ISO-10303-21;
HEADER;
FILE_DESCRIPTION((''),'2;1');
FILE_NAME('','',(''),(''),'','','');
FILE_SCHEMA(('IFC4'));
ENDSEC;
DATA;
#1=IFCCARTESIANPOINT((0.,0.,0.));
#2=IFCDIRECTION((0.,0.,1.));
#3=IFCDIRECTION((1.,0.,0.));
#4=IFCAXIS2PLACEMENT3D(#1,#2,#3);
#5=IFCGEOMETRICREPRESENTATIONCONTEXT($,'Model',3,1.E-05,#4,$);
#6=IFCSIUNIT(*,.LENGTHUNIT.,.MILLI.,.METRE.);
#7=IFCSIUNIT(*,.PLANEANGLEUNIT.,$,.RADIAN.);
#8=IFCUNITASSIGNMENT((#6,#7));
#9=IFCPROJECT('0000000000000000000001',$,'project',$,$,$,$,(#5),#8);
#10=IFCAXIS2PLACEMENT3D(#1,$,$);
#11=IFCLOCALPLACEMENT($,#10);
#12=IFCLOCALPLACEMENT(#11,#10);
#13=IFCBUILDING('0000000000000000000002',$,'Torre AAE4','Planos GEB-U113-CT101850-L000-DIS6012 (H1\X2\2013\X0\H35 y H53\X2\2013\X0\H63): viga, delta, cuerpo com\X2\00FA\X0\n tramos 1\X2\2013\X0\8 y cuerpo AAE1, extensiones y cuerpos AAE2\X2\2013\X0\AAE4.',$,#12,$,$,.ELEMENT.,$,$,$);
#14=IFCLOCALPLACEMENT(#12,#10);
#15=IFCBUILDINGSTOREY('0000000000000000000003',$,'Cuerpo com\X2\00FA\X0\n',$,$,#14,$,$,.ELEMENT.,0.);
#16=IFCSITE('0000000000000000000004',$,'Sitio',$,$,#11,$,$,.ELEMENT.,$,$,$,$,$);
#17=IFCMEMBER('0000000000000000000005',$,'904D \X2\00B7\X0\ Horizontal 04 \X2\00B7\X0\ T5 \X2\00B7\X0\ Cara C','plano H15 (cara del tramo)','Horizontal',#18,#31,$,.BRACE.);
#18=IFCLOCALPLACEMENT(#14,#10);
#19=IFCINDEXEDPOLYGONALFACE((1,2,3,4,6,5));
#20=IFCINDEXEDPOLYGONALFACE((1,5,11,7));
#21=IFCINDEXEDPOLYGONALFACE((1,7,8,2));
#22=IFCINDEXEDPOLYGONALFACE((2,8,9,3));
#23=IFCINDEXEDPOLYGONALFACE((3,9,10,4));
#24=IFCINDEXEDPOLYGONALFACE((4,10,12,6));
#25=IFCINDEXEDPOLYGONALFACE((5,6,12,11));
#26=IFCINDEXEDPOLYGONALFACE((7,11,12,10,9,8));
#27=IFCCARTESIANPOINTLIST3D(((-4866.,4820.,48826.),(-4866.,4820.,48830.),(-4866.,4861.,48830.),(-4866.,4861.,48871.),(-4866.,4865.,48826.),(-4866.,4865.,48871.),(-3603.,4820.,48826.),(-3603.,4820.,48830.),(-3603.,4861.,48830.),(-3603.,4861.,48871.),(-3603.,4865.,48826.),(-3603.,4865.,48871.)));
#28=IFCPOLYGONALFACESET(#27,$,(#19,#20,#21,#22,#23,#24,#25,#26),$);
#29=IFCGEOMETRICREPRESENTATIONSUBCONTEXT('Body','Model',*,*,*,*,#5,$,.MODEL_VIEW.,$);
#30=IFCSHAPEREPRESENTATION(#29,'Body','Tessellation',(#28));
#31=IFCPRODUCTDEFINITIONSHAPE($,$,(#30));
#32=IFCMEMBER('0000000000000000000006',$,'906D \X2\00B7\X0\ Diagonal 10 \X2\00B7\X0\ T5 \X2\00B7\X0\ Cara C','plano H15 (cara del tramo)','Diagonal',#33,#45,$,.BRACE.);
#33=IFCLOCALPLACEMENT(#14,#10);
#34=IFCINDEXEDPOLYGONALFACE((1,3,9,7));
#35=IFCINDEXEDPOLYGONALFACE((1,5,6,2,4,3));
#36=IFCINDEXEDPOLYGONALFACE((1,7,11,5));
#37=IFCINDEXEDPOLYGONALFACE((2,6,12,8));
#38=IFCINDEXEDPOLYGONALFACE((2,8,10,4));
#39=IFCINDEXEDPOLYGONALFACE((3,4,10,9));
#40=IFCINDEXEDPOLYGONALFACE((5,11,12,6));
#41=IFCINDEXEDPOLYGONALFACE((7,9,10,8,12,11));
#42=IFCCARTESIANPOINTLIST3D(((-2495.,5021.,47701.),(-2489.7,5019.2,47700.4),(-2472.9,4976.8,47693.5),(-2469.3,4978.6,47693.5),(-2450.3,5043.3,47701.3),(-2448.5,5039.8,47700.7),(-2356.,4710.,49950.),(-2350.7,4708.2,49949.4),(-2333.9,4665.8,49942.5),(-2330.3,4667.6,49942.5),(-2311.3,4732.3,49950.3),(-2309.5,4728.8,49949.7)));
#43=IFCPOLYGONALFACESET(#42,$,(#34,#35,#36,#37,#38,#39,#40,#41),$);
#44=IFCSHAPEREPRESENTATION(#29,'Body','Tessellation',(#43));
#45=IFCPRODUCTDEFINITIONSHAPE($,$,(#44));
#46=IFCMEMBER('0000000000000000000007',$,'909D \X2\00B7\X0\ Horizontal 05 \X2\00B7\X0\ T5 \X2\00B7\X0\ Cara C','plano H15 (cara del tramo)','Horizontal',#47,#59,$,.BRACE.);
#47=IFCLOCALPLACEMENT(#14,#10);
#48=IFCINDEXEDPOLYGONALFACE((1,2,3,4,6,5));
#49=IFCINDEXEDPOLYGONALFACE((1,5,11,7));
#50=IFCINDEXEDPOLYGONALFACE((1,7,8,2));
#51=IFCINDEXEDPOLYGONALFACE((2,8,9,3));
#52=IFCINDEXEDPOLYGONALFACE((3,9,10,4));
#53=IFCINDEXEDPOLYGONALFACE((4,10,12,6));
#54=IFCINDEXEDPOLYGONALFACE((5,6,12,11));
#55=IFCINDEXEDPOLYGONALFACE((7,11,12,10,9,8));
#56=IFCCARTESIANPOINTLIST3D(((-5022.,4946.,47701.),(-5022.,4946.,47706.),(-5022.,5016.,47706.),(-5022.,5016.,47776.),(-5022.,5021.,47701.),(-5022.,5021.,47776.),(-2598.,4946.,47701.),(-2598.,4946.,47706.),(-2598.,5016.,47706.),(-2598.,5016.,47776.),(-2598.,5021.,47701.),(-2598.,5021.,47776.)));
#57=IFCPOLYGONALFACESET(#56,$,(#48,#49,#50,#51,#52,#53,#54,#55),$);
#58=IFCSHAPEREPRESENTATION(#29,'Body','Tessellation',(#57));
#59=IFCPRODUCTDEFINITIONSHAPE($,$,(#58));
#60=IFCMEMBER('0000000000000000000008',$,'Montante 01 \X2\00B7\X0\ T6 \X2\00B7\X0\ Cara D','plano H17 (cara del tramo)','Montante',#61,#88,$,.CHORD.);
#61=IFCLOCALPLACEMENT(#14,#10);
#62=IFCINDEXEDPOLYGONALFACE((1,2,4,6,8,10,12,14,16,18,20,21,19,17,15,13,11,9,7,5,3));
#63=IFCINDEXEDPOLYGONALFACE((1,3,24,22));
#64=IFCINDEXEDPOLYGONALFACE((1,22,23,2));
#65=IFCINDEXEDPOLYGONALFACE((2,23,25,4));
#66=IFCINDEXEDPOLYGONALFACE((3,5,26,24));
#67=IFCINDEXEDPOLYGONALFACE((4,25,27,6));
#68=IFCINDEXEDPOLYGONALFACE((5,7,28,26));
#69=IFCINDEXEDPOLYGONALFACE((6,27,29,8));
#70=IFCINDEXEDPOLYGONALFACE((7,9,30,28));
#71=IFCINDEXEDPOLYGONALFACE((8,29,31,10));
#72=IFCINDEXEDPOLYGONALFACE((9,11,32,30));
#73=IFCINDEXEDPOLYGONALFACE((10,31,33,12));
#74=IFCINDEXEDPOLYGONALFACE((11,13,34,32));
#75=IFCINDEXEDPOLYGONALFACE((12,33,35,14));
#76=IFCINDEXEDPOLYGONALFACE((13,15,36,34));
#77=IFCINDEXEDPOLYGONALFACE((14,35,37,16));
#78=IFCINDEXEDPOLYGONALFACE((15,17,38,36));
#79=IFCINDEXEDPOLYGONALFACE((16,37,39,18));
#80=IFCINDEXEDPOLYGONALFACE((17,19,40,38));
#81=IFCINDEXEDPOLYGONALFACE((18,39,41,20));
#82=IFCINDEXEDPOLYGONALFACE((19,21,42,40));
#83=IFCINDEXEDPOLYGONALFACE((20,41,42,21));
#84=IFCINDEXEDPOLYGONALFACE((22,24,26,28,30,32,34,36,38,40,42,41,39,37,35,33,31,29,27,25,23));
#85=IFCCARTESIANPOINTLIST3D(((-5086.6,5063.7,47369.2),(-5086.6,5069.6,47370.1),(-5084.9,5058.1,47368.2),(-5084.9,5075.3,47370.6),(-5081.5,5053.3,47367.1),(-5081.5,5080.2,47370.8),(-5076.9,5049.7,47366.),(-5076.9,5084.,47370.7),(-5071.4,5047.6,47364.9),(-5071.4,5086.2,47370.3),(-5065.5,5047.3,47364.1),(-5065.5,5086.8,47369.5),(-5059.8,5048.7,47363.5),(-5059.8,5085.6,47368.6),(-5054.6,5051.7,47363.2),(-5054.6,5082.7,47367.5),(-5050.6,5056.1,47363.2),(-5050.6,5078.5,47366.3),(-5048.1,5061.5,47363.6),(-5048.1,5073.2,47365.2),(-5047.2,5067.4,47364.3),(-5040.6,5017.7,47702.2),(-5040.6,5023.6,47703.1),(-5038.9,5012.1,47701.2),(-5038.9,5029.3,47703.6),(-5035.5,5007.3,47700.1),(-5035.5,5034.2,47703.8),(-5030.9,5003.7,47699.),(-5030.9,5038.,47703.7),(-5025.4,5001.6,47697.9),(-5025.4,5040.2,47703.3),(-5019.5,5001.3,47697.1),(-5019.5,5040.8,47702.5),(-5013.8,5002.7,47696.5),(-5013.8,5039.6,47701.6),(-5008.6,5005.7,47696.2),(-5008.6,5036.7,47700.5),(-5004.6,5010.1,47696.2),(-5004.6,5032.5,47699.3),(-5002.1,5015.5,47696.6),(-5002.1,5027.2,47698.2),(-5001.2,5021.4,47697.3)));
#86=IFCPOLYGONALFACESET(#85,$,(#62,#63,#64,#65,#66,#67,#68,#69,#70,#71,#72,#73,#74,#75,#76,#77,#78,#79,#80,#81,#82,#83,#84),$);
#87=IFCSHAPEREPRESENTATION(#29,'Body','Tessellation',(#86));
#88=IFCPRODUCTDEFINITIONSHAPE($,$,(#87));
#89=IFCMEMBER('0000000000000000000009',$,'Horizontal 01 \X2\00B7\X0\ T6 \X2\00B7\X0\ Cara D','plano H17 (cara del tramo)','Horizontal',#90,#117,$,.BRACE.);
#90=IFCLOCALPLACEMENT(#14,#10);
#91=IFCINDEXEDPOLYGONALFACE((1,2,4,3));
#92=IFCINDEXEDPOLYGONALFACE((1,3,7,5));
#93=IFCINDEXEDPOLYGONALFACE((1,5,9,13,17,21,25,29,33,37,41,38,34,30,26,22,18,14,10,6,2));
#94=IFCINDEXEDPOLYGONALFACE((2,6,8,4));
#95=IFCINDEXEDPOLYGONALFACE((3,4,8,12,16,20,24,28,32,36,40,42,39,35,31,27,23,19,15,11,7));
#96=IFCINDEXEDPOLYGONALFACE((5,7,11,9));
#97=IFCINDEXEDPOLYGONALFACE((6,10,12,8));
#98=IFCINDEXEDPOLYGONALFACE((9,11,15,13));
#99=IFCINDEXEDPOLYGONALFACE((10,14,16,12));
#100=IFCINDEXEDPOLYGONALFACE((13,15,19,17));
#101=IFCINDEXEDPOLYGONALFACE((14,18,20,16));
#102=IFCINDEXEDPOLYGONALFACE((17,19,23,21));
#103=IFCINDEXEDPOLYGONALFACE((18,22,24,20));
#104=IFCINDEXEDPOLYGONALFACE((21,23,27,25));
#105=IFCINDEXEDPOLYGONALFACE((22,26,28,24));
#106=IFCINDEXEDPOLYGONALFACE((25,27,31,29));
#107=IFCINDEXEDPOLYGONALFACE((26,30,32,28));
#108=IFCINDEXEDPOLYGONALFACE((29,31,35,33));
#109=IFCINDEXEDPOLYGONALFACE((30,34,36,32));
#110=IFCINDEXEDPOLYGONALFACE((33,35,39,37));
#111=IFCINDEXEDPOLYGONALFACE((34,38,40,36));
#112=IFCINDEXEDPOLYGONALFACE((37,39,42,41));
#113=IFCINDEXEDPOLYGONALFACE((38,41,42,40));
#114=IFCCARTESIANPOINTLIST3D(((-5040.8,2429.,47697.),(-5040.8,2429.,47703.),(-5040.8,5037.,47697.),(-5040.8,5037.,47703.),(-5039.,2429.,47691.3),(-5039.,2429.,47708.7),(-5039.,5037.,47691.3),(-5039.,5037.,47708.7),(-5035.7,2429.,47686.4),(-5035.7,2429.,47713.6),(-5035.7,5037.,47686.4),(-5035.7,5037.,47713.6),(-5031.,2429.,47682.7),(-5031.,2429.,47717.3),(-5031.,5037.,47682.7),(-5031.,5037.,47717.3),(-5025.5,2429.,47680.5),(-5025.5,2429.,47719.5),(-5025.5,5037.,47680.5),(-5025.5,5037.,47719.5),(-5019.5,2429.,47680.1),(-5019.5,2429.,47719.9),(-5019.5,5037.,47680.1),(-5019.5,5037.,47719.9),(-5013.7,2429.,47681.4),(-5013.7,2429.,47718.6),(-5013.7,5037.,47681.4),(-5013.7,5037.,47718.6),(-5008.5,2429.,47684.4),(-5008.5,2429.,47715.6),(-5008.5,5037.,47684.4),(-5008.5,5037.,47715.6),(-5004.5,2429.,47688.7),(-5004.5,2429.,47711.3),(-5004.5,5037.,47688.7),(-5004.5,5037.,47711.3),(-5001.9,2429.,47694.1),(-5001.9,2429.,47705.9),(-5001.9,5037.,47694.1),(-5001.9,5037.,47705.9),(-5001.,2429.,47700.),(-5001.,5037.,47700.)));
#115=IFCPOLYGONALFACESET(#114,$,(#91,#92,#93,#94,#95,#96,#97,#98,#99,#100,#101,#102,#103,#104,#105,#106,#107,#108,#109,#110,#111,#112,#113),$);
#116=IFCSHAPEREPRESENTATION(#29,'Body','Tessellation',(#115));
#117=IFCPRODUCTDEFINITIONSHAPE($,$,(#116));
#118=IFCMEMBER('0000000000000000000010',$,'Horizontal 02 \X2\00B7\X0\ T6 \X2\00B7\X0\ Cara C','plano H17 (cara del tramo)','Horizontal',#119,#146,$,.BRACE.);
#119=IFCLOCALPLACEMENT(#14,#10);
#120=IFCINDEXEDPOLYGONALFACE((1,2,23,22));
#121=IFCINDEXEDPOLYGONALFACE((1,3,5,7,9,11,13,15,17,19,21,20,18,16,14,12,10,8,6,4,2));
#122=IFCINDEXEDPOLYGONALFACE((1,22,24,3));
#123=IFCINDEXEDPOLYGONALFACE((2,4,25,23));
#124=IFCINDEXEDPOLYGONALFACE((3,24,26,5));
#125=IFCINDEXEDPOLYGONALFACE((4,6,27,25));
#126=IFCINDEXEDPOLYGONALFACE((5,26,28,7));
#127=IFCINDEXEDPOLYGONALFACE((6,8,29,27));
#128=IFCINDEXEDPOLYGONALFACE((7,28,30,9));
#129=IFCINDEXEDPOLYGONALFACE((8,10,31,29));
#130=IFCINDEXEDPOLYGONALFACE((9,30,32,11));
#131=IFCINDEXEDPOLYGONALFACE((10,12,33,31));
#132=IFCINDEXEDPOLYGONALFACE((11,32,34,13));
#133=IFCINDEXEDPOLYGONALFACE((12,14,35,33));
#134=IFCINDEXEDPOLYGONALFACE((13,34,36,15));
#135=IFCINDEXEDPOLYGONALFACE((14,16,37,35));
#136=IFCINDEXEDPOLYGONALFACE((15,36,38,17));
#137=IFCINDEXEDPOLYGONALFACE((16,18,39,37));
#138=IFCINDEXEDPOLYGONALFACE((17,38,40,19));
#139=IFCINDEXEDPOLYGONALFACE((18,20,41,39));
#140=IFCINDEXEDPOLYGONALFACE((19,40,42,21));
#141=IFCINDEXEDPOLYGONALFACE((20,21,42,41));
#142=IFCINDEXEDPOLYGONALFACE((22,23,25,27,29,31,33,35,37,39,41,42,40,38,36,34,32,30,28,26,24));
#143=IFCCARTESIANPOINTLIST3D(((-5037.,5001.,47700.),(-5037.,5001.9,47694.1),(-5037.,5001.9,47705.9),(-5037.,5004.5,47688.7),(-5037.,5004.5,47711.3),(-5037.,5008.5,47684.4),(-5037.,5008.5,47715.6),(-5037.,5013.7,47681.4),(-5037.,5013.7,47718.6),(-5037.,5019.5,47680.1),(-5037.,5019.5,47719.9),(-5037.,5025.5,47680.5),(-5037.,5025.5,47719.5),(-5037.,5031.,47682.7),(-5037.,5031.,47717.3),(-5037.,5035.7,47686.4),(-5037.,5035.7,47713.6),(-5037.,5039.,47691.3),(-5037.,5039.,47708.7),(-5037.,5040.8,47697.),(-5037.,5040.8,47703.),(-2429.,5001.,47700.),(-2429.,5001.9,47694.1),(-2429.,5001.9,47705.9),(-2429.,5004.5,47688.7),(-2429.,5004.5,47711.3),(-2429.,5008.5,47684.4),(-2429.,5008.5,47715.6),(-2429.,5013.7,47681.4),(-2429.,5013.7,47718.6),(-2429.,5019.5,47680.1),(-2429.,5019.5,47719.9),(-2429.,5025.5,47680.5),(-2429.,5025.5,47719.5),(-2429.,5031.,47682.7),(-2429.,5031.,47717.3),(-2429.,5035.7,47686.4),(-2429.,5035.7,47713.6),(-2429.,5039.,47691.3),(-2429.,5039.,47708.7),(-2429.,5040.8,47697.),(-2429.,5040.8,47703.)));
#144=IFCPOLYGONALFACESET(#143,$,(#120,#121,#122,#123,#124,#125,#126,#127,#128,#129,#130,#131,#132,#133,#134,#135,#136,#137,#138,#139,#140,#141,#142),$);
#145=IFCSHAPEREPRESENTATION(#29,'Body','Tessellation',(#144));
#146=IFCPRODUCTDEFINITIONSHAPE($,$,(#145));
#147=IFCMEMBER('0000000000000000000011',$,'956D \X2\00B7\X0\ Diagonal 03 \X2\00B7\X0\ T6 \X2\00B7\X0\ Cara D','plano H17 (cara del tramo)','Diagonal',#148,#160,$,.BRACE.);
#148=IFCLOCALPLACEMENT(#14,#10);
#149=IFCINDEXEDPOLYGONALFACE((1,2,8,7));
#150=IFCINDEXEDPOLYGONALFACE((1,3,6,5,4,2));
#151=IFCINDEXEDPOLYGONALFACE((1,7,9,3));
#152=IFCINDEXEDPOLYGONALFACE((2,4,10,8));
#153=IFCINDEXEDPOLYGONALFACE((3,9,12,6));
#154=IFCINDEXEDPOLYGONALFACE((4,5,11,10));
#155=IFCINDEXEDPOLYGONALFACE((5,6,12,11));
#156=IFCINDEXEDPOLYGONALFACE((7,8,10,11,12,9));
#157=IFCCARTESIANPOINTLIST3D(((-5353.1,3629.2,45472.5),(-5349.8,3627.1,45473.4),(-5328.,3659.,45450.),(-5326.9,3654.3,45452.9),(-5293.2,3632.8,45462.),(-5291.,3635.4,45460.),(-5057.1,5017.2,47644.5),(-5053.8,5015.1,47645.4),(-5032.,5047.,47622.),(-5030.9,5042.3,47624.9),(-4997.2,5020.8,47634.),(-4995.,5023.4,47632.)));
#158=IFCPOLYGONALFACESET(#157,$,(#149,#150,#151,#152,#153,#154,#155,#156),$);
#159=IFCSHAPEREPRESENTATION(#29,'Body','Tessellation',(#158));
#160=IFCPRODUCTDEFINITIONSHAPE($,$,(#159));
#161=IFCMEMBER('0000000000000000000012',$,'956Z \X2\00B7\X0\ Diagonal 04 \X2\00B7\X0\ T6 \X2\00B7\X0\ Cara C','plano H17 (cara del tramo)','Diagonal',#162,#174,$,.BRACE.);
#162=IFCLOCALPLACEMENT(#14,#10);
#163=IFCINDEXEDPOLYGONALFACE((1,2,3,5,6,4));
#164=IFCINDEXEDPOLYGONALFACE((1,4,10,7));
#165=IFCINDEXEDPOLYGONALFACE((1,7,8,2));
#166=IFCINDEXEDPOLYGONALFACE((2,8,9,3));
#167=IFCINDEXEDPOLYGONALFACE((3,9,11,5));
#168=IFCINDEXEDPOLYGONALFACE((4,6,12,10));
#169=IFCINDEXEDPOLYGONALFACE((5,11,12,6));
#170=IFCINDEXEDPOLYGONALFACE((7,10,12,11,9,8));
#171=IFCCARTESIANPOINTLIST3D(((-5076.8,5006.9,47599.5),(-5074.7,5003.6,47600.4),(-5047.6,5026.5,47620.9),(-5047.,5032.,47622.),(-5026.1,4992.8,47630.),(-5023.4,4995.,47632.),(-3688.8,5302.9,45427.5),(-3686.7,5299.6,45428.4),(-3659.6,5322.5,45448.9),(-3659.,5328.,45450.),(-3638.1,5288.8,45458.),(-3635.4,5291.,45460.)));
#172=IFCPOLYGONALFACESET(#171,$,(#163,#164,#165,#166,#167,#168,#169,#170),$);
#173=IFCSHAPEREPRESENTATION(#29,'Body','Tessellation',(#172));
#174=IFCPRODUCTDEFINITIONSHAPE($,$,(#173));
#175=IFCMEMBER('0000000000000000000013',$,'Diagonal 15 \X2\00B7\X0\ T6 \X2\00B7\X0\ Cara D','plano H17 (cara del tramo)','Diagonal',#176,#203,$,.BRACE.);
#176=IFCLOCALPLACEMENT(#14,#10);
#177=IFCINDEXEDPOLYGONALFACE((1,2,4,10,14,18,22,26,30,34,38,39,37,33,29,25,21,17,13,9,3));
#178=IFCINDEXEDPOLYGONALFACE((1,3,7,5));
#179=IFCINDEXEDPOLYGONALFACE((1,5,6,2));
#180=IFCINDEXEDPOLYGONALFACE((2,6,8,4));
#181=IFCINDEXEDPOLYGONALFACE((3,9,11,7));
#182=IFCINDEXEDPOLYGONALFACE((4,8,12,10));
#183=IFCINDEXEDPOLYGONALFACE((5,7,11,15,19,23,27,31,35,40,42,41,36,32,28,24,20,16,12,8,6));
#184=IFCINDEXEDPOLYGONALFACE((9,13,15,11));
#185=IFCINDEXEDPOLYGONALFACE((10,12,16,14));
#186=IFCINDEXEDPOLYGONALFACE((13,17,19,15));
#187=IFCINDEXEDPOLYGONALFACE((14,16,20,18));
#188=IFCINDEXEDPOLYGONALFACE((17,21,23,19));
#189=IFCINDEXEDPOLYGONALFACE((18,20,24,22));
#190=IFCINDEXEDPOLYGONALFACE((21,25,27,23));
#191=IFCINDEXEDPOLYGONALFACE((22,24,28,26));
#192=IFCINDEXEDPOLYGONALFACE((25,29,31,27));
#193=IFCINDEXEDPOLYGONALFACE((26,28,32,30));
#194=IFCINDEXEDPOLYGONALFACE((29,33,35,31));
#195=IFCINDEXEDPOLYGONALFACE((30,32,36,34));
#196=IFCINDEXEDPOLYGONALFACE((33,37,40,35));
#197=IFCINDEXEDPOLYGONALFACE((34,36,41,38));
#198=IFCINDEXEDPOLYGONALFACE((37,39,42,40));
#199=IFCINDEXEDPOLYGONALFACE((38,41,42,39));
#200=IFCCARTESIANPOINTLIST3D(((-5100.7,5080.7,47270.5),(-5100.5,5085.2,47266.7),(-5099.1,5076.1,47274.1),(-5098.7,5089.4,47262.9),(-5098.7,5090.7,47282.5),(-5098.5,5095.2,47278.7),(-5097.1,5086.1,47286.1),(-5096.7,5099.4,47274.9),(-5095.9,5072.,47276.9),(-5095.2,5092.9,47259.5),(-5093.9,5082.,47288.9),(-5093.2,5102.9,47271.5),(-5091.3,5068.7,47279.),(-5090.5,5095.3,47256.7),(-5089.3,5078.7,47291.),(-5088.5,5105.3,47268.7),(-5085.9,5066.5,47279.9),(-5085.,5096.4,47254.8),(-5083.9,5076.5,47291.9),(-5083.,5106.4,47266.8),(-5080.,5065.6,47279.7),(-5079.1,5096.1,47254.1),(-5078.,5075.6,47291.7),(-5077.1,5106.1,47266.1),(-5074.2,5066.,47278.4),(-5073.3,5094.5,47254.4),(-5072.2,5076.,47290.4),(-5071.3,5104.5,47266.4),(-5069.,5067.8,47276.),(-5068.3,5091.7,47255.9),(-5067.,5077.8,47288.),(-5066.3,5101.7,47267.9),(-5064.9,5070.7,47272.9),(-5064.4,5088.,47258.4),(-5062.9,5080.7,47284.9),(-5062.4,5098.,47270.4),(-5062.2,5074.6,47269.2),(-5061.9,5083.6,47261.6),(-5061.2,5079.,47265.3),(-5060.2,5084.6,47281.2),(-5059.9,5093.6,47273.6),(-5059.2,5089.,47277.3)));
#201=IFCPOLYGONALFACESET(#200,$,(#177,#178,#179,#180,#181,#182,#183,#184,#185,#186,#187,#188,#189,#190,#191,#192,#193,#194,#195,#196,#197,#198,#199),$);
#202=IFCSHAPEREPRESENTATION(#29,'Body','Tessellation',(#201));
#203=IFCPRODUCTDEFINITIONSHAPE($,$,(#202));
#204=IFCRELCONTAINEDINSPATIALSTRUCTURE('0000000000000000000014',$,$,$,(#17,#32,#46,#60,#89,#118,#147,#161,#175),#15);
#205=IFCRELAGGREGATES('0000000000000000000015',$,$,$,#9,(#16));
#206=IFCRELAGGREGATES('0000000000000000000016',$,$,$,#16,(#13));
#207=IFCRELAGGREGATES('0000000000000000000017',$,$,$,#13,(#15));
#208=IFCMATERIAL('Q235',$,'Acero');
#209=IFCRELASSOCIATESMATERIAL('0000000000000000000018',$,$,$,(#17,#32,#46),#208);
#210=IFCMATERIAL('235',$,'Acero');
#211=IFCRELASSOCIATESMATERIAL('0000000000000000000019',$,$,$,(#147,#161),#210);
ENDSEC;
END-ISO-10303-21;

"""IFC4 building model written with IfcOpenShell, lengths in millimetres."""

from ifc_helpers import new_model, si_unit, frame, frame_2d, origin, origin_with_axes, place, context, subcontext, project, spatial, circle, l_section, extrude, material, element, save


model = new_model("IFC4")

# Units and contexts
model_context = context("Model", 3, precision=1e-05, world=origin_with_axes())
body_context = subcontext(model_context, "Body", "Model", "MODEL_VIEW")
ifc_project = project(units=[si_unit("LENGTHUNIT", "METRE", prefix="MILLI"), si_unit("PLANEANGLEUNIT", "RADIAN")], contexts=[model_context])

# Site, building, storey
site_placement = place(None, origin())
site = spatial("IfcSite", under=ifc_project, at=site_placement, Name="Sitio", CompositionType="ELEMENT")
building_placement = place(site_placement, origin())
building = spatial("IfcBuilding", under=site, at=building_placement, Name="Torre AAE4", Description="Planos GEB-U113-CT101850-L000-DIS6012 (H1–H35 y H53–H63): viga, delta, cuerpo común tramos 1–8 y cuerpo AAE1, extensiones y cuerpos AAE2–AAE4.", CompositionType="ELEMENT")
storey_placement = place(building_placement, origin())
storey = spatial("IfcBuildingStorey", under=building, at=storey_placement, Name="Cuerpo común", CompositionType="ELEMENT", Elevation=0.0)

# Members
ifc_material_1 = material(Name="Q235", Category="Acero")
member_1_placement = place(storey_placement, frame((-3603.0, 4865.0, 48826.0), z_axis=(-1.0, 0.0, 0.0), x_axis=(0.0, -1.0, 0.0)))
element("IfcMember", 1, at=member_1_placement, inside=storey, material=ifc_material_1, Name="904D · Horizontal 04 · T5 · Cara C", Description="plano H15 (cara del tramo)", ObjectType="Horizontal", PredefinedType="BRACE", context=body_context, shape_type="SweptSolid", body=[
    extrude(l_section(Depth=45.0, Width=45.0, Thickness=4.0, at=frame_2d((22.5, 22.5))), None, (0.0, 0.0, 1.0), 1263.0),
])
member_2_placement = place(storey_placement, frame((-2495.0, 5021.0, 47701.0), z_axis=(0.061108, -0.136724, 0.988723), x_axis=(0.441979, -0.884459, -0.149623)))
element("IfcMember", 2, at=member_2_placement, inside=storey, material=ifc_material_1, Name="906D · Diagonal 10 · T5 · Cara C", Description="plano H15 (cara del tramo)", ObjectType="Diagonal", PredefinedType="BRACE", context=body_context, shape_type="SweptSolid", body=[
    extrude(l_section(Depth=50.0, Width=50.0, Thickness=4.0, at=frame_2d((25.0, 25.0))), None, (0.0, 0.0, 1.0), 2274.7),
])
member_3_placement = place(storey_placement, frame((-2598.0, 5021.0, 47701.0), z_axis=(-1.0, 0.0, 0.0), x_axis=(0.0, -1.0, 0.0)))
element("IfcMember", 3, at=member_3_placement, inside=storey, material=ifc_material_1, Name="909D · Horizontal 05 · T5 · Cara C", Description="plano H15 (cara del tramo)", ObjectType="Horizontal", PredefinedType="BRACE", context=body_context, shape_type="SweptSolid", body=[
    extrude(l_section(Depth=75.0, Width=75.0, Thickness=5.0, at=frame_2d((37.5, 37.5))), None, (0.0, 0.0, 1.0), 2424.0),
])
member_4_placement = place(storey_placement, frame((-5021.0, 5021.0, 47700.0), z_axis=(-0.135575, 0.135575, -0.981447), x_axis=(0.990767, 0.018552, -0.1343)))
element("IfcMember", 4, at=member_4_placement, inside=storey, Name="Montante 01 · T6 · Cara D", Description="plano H17 (cara del tramo)", ObjectType="Montante", PredefinedType="CHORD", context=body_context, shape_type="SweptSolid", body=[
    extrude(circle(Radius=20.0), None, (0.0, 0.0, 1.0), 339.3),
])
for number, where, z_axis, x_axis, name in (
    (5, (-5021.0, 5037.0, 47700.0), (0.0, -1.0, 0.0), (1.0, 0.0, 0.0), "Horizontal 01 · T6 · Cara D"),
    (6, (-5037.0, 5021.0, 47700.0), (1.0, 0.0, 0.0), (0.0, -1.0, 0.0), "Horizontal 02 · T6 · Cara C"),
):
    element("IfcMember", number, at=place(storey_placement, frame(where, z_axis=z_axis, x_axis=x_axis)), inside=storey, Name=name, Description="plano H17 (cara del tramo)", ObjectType="Horizontal", PredefinedType="BRACE", context=body_context, shape_type="SweptSolid", body=[
        extrude(circle(Radius=20.0), None, (0.0, 0.0, 1.0), 2608.0),
    ])
ifc_material_2 = material(Name="235", Category="Acero")
for number, where, z_axis, x_axis, name in (
    (7, (-5032.0, 5047.0, 47622.0), (-0.114085, -0.534965, -0.837136), (0.822462, -0.523514, 0.222463), "956D · Diagonal 03 · T6 · Cara D"),
    (8, (-5047.0, 5032.0, 47622.0), (0.534965, 0.114085, -0.837136), (0.523514, -0.822462, 0.222463), "956Z · Diagonal 04 · T6 · Cara C"),
):
    element("IfcMember", number, at=place(storey_placement, frame(where, z_axis=z_axis, x_axis=x_axis)), inside=storey, material=ifc_material_2, Name=name, Description="plano H17 (cara del tramo)", ObjectType="Diagonal", PredefinedType="BRACE", context=body_context, shape_type="SweptSolid", body=[
        extrude(l_section(Depth=45.0, Width=45.0, Thickness=4.0, at=frame_2d((22.5, 22.5))), None, (0.0, 0.0, 1.0), 2594.6),
    ])
member_5_placement = place(storey_placement, frame((-5079.0, 5091.0, 47279.0), z_axis=(-0.127, -0.635001, -0.762001), x_axis=(0.806261, -0.513563, 0.293592)))
element("IfcMember", 9, at=member_5_placement, inside=storey, Name="Diagonal 15 · T6 · Cara D", Description="plano H17 (cara del tramo)", ObjectType="Diagonal", PredefinedType="BRACE", context=body_context, shape_type="SweptSolid", body=[
    extrude(circle(Radius=20.0), None, (0.0, 0.0, 1.0), 15.7),
])

save(model, "model.ifc")
